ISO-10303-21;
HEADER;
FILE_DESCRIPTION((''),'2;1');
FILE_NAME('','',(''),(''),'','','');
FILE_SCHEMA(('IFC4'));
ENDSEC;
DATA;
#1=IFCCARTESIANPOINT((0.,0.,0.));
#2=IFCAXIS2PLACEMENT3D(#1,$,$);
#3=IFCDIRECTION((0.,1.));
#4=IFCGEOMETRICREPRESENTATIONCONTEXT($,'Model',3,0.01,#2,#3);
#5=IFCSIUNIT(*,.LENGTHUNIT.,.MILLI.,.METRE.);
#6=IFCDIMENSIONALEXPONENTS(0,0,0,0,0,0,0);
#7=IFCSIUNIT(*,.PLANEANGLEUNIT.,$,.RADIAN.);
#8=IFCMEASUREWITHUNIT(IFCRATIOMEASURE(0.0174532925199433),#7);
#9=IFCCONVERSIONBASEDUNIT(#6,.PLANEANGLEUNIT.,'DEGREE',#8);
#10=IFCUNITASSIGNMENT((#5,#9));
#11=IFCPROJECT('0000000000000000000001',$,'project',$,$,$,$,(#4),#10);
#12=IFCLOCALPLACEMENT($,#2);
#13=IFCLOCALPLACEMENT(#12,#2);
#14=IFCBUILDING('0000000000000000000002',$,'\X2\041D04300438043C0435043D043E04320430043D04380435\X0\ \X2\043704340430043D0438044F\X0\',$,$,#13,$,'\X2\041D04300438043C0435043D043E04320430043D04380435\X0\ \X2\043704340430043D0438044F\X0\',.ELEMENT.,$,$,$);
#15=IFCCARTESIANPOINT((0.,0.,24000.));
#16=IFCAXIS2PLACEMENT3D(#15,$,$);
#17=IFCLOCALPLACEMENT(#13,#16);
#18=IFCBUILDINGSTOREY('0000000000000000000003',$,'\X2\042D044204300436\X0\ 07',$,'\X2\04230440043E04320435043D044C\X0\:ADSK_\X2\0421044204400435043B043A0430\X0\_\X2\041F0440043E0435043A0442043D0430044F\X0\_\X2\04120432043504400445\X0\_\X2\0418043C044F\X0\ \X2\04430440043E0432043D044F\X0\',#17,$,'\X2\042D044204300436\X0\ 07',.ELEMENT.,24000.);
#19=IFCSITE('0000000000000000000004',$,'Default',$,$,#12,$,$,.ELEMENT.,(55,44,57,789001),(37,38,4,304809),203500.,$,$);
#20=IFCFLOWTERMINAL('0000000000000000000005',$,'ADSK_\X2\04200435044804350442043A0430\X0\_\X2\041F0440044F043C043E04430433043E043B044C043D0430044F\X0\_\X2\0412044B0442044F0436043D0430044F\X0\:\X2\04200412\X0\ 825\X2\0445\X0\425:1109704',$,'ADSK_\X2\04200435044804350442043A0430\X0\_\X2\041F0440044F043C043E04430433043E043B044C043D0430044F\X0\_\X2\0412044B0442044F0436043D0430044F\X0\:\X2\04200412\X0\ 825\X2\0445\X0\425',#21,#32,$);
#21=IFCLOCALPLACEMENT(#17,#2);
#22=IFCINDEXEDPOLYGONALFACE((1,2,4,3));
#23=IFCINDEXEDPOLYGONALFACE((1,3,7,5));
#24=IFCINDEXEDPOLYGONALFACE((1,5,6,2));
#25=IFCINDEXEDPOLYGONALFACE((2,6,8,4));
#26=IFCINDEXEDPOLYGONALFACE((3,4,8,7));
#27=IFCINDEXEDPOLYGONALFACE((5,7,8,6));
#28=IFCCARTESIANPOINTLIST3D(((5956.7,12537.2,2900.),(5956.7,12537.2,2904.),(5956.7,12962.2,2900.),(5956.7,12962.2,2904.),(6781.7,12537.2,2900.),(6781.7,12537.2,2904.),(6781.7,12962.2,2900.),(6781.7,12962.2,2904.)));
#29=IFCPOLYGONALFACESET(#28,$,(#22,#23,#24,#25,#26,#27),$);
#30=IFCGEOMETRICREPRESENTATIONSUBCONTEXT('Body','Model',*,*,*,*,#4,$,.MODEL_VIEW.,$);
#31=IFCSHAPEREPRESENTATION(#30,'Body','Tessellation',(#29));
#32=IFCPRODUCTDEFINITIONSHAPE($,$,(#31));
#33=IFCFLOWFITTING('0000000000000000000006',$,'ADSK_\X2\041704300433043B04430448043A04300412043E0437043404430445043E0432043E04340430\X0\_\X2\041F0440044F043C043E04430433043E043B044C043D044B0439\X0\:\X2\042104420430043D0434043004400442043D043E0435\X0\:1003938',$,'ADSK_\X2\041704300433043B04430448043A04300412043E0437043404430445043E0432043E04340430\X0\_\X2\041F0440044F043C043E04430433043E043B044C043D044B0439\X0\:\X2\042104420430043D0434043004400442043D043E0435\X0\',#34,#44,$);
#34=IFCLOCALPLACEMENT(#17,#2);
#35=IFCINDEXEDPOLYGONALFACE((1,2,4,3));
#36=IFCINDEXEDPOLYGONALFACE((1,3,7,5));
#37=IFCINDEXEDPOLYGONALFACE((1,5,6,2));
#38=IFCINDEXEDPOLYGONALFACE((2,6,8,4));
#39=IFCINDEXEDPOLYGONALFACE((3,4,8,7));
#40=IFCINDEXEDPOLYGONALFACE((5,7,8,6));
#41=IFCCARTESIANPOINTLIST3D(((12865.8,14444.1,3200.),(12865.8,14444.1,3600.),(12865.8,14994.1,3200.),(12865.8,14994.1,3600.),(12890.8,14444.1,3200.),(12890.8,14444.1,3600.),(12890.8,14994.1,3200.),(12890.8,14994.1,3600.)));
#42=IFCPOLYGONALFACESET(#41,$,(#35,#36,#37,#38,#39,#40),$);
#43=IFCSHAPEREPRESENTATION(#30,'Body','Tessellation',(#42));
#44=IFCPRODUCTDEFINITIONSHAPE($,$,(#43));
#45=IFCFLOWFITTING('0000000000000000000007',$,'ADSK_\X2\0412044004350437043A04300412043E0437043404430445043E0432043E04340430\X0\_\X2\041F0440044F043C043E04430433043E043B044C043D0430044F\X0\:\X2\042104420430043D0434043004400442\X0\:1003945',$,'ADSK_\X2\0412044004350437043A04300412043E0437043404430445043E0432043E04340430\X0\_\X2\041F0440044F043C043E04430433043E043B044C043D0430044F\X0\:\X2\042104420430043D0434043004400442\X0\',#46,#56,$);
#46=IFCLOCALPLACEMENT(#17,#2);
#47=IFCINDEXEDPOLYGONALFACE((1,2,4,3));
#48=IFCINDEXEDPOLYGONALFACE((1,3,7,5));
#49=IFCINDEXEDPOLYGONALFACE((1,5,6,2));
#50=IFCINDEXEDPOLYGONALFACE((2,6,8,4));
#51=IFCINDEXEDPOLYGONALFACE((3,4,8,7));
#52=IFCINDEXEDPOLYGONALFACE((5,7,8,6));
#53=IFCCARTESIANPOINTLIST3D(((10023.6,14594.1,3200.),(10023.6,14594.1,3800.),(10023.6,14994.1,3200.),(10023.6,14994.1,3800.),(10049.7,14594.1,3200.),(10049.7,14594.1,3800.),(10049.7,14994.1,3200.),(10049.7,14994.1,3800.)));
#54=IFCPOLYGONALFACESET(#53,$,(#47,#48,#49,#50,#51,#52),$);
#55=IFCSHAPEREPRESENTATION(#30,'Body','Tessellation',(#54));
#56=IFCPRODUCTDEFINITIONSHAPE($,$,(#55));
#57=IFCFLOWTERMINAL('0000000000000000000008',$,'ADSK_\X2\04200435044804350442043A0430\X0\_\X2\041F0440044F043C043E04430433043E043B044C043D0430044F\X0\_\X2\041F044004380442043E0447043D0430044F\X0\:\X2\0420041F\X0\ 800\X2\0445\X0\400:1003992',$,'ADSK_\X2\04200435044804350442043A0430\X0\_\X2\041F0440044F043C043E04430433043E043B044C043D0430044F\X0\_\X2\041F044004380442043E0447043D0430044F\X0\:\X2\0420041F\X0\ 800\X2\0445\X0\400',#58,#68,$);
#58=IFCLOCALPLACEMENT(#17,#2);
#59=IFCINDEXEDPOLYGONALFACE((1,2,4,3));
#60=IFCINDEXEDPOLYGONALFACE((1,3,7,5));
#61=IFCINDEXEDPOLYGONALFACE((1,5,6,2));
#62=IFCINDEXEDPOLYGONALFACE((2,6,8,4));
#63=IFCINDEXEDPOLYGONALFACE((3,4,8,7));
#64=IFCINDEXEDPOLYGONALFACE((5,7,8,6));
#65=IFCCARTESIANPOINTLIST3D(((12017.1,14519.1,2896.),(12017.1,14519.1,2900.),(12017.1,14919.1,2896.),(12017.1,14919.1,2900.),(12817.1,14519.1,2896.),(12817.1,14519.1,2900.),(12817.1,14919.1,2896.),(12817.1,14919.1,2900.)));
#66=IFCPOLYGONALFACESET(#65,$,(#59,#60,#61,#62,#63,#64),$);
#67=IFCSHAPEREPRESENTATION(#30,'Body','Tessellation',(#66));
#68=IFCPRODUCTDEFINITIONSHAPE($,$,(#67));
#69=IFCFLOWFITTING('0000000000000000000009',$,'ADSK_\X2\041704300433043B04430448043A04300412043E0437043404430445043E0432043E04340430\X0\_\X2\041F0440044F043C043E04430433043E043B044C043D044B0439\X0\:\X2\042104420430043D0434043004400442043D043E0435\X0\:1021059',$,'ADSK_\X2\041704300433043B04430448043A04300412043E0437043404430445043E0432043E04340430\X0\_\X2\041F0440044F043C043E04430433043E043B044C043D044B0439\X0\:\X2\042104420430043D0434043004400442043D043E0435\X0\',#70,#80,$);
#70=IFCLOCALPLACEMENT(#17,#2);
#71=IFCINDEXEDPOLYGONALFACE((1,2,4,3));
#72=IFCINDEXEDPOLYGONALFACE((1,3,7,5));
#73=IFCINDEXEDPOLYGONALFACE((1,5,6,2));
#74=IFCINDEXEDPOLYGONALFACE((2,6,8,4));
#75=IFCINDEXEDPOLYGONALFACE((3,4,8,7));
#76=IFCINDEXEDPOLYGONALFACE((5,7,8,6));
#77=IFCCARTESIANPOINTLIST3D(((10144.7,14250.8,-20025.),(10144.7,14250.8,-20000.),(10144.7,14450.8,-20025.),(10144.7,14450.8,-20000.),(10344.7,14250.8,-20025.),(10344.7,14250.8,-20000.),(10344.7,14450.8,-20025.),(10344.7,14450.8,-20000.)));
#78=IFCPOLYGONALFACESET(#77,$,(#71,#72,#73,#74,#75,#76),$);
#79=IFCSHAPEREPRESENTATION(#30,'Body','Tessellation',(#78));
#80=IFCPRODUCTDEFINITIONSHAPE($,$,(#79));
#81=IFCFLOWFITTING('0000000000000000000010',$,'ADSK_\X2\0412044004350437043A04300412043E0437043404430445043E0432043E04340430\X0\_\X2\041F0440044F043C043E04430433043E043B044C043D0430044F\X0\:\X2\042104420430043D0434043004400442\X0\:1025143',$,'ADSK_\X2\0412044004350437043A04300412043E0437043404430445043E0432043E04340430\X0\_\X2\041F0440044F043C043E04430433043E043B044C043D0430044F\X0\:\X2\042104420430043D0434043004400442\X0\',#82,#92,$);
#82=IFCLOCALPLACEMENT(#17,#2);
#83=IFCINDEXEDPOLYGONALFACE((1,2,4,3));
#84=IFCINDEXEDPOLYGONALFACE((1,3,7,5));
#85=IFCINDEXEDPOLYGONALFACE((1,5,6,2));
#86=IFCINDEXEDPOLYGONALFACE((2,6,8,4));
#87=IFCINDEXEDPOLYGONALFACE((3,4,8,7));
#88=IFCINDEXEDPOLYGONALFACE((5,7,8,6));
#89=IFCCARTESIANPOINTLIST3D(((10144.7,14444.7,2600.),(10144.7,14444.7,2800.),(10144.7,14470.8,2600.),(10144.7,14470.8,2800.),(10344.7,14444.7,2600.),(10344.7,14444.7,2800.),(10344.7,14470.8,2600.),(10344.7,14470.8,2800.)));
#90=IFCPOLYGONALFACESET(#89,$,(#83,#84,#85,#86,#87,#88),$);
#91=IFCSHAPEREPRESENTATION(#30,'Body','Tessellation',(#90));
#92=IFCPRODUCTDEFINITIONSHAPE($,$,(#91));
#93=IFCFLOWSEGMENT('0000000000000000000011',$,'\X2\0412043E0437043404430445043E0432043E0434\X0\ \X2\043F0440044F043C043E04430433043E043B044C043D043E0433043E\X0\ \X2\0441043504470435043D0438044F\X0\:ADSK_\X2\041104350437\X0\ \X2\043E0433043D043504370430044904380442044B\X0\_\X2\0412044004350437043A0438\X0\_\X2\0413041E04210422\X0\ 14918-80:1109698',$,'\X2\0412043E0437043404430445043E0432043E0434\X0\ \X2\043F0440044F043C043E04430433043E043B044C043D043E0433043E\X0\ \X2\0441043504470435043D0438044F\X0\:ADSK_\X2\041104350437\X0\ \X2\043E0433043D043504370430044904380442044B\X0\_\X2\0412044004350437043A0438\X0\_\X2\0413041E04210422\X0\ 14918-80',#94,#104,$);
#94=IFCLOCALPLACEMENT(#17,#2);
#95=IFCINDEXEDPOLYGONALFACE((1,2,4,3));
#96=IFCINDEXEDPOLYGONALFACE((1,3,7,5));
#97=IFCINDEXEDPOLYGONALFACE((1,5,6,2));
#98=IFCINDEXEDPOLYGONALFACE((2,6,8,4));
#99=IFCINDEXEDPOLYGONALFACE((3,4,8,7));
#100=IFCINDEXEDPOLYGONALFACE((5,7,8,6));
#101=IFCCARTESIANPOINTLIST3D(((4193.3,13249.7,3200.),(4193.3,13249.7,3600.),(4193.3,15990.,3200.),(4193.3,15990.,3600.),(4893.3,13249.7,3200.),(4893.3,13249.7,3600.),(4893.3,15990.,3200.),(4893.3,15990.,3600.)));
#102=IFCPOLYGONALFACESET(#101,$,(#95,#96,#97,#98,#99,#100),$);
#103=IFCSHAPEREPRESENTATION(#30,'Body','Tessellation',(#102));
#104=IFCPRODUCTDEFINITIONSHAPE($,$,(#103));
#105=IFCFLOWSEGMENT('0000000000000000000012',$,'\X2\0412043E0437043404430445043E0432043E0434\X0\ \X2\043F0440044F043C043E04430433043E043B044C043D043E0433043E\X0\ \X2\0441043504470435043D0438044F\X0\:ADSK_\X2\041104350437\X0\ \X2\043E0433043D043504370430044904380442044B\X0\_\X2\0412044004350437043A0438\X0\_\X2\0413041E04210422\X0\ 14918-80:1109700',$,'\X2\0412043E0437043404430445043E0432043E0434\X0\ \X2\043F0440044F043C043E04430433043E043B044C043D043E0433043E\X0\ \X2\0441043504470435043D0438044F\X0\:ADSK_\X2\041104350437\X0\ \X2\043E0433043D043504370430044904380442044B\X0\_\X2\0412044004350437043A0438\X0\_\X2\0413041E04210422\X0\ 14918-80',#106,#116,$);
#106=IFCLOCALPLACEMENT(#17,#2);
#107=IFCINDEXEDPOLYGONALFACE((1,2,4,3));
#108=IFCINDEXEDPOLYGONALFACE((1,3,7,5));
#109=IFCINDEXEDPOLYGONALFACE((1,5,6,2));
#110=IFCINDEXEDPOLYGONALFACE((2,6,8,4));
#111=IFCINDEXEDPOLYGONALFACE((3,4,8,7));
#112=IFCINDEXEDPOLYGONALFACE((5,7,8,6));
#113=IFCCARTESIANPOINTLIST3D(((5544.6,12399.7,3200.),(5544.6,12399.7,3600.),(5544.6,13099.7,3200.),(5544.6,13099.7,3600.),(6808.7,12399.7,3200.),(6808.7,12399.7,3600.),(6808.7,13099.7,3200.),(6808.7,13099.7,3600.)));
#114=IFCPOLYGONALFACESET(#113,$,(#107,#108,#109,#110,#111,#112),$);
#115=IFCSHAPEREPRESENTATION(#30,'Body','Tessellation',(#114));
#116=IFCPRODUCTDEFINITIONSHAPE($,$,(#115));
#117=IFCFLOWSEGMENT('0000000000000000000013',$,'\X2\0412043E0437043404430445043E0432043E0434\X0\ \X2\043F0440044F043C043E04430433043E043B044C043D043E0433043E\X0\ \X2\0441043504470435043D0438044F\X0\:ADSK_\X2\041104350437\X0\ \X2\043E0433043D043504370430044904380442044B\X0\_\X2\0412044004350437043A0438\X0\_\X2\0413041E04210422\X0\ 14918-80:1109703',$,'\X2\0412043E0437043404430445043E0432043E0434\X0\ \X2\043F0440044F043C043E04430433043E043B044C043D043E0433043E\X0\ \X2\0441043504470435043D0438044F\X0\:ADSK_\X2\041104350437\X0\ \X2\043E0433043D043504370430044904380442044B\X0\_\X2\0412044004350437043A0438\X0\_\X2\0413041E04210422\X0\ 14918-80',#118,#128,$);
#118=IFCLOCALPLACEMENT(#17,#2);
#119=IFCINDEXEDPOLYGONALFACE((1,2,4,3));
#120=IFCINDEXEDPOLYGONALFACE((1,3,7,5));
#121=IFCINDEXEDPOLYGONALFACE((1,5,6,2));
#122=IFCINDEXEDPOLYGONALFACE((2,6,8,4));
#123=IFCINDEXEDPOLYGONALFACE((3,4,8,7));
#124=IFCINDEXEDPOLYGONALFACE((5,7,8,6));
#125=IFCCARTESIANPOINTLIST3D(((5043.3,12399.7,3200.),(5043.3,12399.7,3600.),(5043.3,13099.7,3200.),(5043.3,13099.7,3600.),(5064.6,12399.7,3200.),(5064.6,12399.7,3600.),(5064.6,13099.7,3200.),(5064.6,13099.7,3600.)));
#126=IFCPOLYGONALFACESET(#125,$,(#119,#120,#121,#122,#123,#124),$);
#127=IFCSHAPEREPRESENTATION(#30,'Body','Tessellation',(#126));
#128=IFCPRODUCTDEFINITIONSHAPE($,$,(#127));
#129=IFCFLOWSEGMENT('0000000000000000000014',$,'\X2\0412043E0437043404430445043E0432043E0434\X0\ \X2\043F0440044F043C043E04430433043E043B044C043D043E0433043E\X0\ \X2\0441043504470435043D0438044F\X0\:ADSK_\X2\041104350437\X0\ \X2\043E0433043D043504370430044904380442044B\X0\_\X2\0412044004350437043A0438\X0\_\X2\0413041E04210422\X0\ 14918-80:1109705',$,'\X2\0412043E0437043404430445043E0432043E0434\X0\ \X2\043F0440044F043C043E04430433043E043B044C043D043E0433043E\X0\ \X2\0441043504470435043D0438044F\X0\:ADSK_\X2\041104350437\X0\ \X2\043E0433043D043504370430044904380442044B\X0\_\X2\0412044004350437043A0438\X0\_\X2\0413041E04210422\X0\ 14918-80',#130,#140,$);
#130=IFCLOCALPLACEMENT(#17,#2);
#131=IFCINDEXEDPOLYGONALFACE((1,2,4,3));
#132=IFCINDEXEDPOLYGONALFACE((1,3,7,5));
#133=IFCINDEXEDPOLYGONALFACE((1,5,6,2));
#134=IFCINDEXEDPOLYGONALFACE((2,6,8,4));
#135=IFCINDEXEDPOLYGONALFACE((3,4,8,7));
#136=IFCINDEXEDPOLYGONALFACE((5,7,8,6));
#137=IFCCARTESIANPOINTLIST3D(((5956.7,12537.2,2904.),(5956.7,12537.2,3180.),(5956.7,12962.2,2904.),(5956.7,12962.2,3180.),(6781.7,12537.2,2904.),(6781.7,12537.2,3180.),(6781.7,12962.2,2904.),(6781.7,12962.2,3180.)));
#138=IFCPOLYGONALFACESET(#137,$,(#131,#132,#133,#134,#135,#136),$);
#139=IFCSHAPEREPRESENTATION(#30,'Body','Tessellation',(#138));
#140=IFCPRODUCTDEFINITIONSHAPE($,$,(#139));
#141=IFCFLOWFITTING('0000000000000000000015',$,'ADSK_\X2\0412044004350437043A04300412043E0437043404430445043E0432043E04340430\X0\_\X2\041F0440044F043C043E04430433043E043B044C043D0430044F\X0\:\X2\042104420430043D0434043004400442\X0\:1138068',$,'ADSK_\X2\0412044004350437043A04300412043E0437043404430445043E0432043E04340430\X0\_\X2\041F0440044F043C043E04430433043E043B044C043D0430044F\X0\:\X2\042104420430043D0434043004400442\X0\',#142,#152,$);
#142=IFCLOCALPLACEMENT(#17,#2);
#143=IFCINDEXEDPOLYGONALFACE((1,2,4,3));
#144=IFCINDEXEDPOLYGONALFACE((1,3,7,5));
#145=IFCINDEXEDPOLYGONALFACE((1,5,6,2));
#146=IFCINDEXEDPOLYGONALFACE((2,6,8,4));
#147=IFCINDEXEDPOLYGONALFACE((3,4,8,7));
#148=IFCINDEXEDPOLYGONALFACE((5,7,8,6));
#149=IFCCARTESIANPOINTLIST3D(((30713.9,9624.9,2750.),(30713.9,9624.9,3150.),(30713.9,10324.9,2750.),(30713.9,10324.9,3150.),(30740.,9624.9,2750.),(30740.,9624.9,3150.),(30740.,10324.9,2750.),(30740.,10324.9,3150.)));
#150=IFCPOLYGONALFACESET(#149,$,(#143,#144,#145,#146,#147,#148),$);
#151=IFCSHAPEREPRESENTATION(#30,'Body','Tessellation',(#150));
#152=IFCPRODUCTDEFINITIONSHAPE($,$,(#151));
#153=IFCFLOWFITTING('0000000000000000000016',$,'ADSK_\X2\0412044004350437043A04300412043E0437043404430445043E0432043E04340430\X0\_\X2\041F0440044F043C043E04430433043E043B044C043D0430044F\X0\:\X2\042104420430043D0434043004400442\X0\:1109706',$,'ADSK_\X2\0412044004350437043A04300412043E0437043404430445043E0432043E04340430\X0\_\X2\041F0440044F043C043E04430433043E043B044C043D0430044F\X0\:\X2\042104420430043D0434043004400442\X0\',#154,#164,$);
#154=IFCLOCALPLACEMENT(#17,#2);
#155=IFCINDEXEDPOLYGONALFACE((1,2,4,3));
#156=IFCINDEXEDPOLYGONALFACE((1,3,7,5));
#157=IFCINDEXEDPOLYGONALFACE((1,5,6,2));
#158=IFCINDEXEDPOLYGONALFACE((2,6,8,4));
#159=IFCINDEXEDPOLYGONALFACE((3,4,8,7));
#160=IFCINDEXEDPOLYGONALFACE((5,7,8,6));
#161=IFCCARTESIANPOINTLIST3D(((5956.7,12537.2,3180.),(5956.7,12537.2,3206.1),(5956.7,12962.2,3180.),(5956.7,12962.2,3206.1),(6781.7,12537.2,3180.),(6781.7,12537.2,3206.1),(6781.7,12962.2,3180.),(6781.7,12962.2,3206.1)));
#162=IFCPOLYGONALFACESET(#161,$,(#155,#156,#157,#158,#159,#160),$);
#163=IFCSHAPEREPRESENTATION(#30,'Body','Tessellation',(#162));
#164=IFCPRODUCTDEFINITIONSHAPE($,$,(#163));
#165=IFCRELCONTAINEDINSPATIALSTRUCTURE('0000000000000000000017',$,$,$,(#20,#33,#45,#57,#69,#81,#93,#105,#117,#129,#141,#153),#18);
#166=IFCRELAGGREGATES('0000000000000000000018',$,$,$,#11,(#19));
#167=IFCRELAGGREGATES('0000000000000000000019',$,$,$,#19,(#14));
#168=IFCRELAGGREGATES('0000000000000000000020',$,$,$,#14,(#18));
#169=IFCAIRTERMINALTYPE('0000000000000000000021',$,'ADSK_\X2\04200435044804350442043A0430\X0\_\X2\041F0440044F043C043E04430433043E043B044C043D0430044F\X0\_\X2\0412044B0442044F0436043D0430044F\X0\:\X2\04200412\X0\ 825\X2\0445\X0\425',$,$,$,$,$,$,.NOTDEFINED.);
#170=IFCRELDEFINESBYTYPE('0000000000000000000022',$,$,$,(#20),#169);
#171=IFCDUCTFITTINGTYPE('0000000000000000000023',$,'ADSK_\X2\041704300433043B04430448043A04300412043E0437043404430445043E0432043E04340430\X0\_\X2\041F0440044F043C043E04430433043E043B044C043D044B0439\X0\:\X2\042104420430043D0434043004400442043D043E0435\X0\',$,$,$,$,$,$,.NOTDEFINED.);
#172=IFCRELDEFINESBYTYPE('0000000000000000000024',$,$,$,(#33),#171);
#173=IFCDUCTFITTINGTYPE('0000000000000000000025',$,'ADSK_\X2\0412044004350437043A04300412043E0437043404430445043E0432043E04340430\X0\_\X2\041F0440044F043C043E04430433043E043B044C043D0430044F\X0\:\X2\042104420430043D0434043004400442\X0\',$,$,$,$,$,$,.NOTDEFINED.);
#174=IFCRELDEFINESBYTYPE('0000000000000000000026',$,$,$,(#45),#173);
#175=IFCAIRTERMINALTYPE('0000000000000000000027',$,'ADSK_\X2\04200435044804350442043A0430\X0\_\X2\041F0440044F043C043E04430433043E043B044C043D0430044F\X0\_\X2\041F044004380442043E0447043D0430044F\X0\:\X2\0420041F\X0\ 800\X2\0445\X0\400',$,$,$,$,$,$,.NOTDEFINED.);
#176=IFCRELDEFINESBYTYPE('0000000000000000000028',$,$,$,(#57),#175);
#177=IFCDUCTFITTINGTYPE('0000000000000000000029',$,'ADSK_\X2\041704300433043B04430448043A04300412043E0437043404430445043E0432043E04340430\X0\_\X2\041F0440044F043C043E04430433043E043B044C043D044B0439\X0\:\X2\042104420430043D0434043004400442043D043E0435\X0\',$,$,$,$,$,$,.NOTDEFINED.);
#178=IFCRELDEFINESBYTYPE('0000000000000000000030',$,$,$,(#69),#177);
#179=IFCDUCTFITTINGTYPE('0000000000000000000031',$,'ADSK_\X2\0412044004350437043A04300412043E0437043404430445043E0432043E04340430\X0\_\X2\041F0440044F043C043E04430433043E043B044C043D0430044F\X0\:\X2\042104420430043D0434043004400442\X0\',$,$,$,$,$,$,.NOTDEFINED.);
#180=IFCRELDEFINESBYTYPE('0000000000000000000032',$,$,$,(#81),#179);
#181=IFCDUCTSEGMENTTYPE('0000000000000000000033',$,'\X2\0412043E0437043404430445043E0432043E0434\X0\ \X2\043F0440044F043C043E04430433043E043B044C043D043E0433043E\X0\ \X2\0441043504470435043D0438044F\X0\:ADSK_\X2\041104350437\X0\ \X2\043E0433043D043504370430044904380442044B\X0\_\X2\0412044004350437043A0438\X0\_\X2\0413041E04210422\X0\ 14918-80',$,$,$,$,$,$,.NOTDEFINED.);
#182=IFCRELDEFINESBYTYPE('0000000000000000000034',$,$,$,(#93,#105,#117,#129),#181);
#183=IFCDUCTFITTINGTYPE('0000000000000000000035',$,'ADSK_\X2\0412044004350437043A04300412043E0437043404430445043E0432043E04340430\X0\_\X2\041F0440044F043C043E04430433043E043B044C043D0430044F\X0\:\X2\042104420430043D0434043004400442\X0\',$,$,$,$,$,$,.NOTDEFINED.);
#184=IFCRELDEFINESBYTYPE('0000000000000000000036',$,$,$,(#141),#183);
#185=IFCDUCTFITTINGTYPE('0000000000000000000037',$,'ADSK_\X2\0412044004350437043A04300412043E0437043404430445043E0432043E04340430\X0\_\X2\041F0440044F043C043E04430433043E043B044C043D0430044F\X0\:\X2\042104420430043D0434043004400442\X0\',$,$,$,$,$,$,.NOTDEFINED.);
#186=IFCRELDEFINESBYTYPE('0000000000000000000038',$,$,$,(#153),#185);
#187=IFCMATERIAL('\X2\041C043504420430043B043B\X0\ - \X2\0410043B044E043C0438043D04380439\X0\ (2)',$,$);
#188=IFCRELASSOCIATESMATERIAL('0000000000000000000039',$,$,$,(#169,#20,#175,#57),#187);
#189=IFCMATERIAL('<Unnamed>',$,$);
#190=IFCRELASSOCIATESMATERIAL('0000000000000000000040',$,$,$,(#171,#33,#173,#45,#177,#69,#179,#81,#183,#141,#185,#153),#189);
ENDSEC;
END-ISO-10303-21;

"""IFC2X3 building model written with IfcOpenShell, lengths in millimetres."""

from ifc_helpers import new_model, entity, si_unit, converted_unit, direction, frame, frame_2d, origin, origin_2d_with_axis, place, context, subcontext, project, spatial, rectangle, extrude, source, transform, mapped, material, type_object, type_shapes, element, save


model = new_model("IFC2X3")

# Units and contexts
model_context = context("Model", 3, precision=0.01, world=origin(), true_north=direction((0.0, 1.0)))
body_context = subcontext(model_context, "Body", "Model", "MODEL_VIEW")
ifc_project = project(units=[si_unit("LENGTHUNIT", "METRE", prefix="MILLI"), converted_unit("PLANEANGLEUNIT", "DEGREE", entity("IfcRatioMeasure", 0.0174532925199433), si_unit("PLANEANGLEUNIT", "RADIAN"), dimensions=[0, 0, 0, 0, 0, 0, 0])], contexts=[model_context])

# Site, building, storey
site_placement = place(None, frame((0.0, 0.0, 0.0)))
site = spatial("IfcSite", under=ifc_project, at=site_placement, Name="Default", CompositionType="ELEMENT", RefLatitude=(55, 44, 57, 789001), RefLongitude=(37, 38, 4, 304809), RefElevation=203500.0)
building_placement = place(site_placement, origin())
building = spatial("IfcBuilding", under=site, at=building_placement, Name="Наименование здания", LongName="Наименование здания", CompositionType="ELEMENT")
storey_placement = place(building_placement, frame((0.0, 0.0, 24000.0)))
storey = spatial("IfcBuildingStorey", under=building, at=storey_placement, Name="Этаж 07", ObjectType="Уровень:ADSK_Стрелка_Проектная_Вверх_Имя уровня", LongName="Этаж 07", CompositionType="ELEMENT", Elevation=24000.0)

# Shared definitions
ifc_material_1 = material(Name="<Unnamed>")

# Flow terminal
ifc_material_2 = material(Name="Металл - Алюминий (2)")
air_terminal_type_1 = type_object("IfcAirTerminalType", Name="ADSK_Решетка_Прямоугольная_Вытяжная:РВ 825х425", PredefinedType="NOTDEFINED", material=ifc_material_2)
shared_shape_1 = source(origin(), body_context, "Body", "SweptSolid", [
    extrude(rectangle(XDim=4.0, YDim=825.0, at=origin_2d_with_axis()), frame((0.0, -2.0, -212.5), z_axis=(0.0, 0.0, 1.0), x_axis=(0.0, 1.0, 0.0)), (0.0, 0.0, 1.0), 425.0),
])
type_shapes(air_terminal_type_1, [shared_shape_1])
flow_terminal_1_placement = place(storey_placement, frame((6369.2, 12749.7, 2904.0), z_axis=(0.0, 1.0, 0.0), x_axis=(-1.0, 0.0, 0.0)))
element("IfcFlowTerminal", 1, at=flow_terminal_1_placement, inside=storey, type_object=air_terminal_type_1, material=ifc_material_2, Name="ADSK_Решетка_Прямоугольная_Вытяжная:РВ 825х425:1109704", ObjectType="ADSK_Решетка_Прямоугольная_Вытяжная:РВ 825х425", context=body_context, shape_type="MappedRepresentation", body=[
    mapped(shared_shape_1, transform((0.0, 0.0, 0.0), scale=1.0)),
])

# Flow fittings
duct_fitting_type_1 = type_object("IfcDuctFittingType", Name="ADSK_ЗаглушкаВоздуховода_Прямоугольный:Стандартное", PredefinedType="NOTDEFINED", material=ifc_material_1)
shared_shape_2 = source(origin(), body_context, "Body", "SweptSolid", [
    extrude(rectangle(XDim=25.0, YDim=550.0, at=frame_2d((0.0, 0.0), x_axis=(1.0, 0.0))), frame((12.5, 0.0, -200.0)), (0.0, 0.0, 1.0), 400.0),
])
type_shapes(duct_fitting_type_1, [shared_shape_2])
flow_fitting_1_placement = place(storey_placement, frame((12865.8, 14719.1, 3400.0)))
element("IfcFlowFitting", 2, at=flow_fitting_1_placement, inside=storey, type_object=duct_fitting_type_1, material=ifc_material_1, Name="ADSK_ЗаглушкаВоздуховода_Прямоугольный:Стандартное:1003938", ObjectType="ADSK_ЗаглушкаВоздуховода_Прямоугольный:Стандартное", context=body_context, shape_type="MappedRepresentation", body=[
    mapped(shared_shape_2, transform((0.0, 0.0, 0.0), scale=1.0)),
])
duct_fitting_type_2 = type_object("IfcDuctFittingType", Name="ADSK_ВрезкаВоздуховода_Прямоугольная:Стандарт", PredefinedType="NOTDEFINED", material=ifc_material_1)
shared_shape_3 = source(origin(), body_context, "Body", "SweptSolid", [
    extrude(rectangle(XDim=600.0, YDim=26.1, at=origin_2d_with_axis()), frame((7.0, 0.0, -200.0), z_axis=(0.0, 0.0, 1.0), x_axis=(0.0, -1.0, 0.0)), (0.0, 0.0, 1.0), 400.0),
])
type_shapes(duct_fitting_type_2, [shared_shape_3])
flow_fitting_2_placement = place(storey_placement, frame((10029.7, 14794.1, 3500.0), z_axis=(0.0, -1.0, 0.0), x_axis=(1.0, 0.0, 0.0)))
element("IfcFlowFitting", 3, at=flow_fitting_2_placement, inside=storey, type_object=duct_fitting_type_2, material=ifc_material_1, Name="ADSK_ВрезкаВоздуховода_Прямоугольная:Стандарт:1003945", ObjectType="ADSK_ВрезкаВоздуховода_Прямоугольная:Стандарт", context=body_context, shape_type="MappedRepresentation", body=[
    mapped(shared_shape_3, transform((0.0, 0.0, 0.0), scale=1.0)),
])

# Flow terminal
air_terminal_type_2 = type_object("IfcAirTerminalType", Name="ADSK_Решетка_Прямоугольная_Приточная:РП 800х400", PredefinedType="NOTDEFINED", material=ifc_material_2)
shared_shape_4 = source(origin(), body_context, "Body", "SweptSolid", [
    extrude(rectangle(XDim=4.0, YDim=800.0, at=origin_2d_with_axis()), frame((0.0, -2.0, -200.0), z_axis=(0.0, 0.0, 1.0), x_axis=(0.0, 1.0, 0.0)), (0.0, 0.0, 1.0), 400.0),
])
type_shapes(air_terminal_type_2, [shared_shape_4])
flow_terminal_2_placement = place(storey_placement, frame((12417.1, 14719.1, 2900.0), z_axis=(0.0, 1.0, 0.0), x_axis=(-1.0, 0.0, 0.0)))
element("IfcFlowTerminal", 4, at=flow_terminal_2_placement, inside=storey, type_object=air_terminal_type_2, material=ifc_material_2, Name="ADSK_Решетка_Прямоугольная_Приточная:РП 800х400:1003992", ObjectType="ADSK_Решетка_Прямоугольная_Приточная:РП 800х400", context=body_context, shape_type="MappedRepresentation", body=[
    mapped(shared_shape_4, transform((0.0, 0.0, 0.0), scale=1.0)),
])

# Flow fittings
duct_fitting_type_3 = type_object("IfcDuctFittingType", Name="ADSK_ЗаглушкаВоздуховода_Прямоугольный:Стандартное", PredefinedType="NOTDEFINED", material=ifc_material_1)
shared_shape_5 = source(origin(), body_context, "Body", "SweptSolid", [
    extrude(rectangle(XDim=25.0, YDim=200.0, at=frame_2d((0.0, 0.0), x_axis=(1.0, 0.0))), frame((12.5, 0.0, -100.0)), (0.0, 0.0, 1.0), 200.0),
])
type_shapes(duct_fitting_type_3, [shared_shape_5])
flow_fitting_3_placement = place(storey_placement, frame((10244.7, 14350.8, -20000.0), z_axis=(0.0, -1.0, 0.0), x_axis=(0.0, 0.0, -1.0)))
element("IfcFlowFitting", 5, at=flow_fitting_3_placement, inside=storey, type_object=duct_fitting_type_3, material=ifc_material_1, Name="ADSK_ЗаглушкаВоздуховода_Прямоугольный:Стандартное:1021059", ObjectType="ADSK_ЗаглушкаВоздуховода_Прямоугольный:Стандартное", context=body_context, shape_type="MappedRepresentation", body=[
    mapped(shared_shape_5, transform((0.0, 0.0, 0.0), scale=1.0)),
])
duct_fitting_type_4 = type_object("IfcDuctFittingType", Name="ADSK_ВрезкаВоздуховода_Прямоугольная:Стандарт", PredefinedType="NOTDEFINED", material=ifc_material_1)
shared_shape_6 = source(origin(), body_context, "Body", "SweptSolid", [
    extrude(rectangle(XDim=200.0, YDim=26.1, at=frame_2d((0.0, 0.0), x_axis=(1.0, 0.0))), frame((7.0, 0.0, -100.0), z_axis=(0.0, 0.0, 1.0), x_axis=(0.0, -1.0, 0.0)), (0.0, 0.0, 1.0), 200.0),
])
type_shapes(duct_fitting_type_4, [shared_shape_6])
flow_fitting_4_placement = place(storey_placement, frame((10244.7, 14450.8, 2700.0), z_axis=(1.0, 0.0, 0.0), x_axis=(0.0, 1.0, 0.0)))
element("IfcFlowFitting", 6, at=flow_fitting_4_placement, inside=storey, type_object=duct_fitting_type_4, material=ifc_material_1, Name="ADSK_ВрезкаВоздуховода_Прямоугольная:Стандарт:1025143", ObjectType="ADSK_ВрезкаВоздуховода_Прямоугольная:Стандарт", context=body_context, shape_type="MappedRepresentation", body=[
    mapped(shared_shape_6, transform((0.0, 0.0, 0.0), scale=1.0)),
])

# Flow segments
duct_segment_type_1 = type_object("IfcDuctSegmentType", Name="Воздуховод прямоугольного сечения:ADSK_Без огнезащиты_Врезки_ГОСТ 14918-80", PredefinedType="NOTDEFINED")
flow_segment_1_placement = place(storey_placement, frame((4193.3, 13249.7, 3200.0)))
element("IfcFlowSegment", 7, at=flow_segment_1_placement, inside=storey, type_object=duct_segment_type_1, Name="Воздуховод прямоугольного сечения:ADSK_Без огнезащиты_Врезки_ГОСТ 14918-80:1109698", ObjectType="Воздуховод прямоугольного сечения:ADSK_Без огнезащиты_Врезки_ГОСТ 14918-80", context=body_context, shape_type="SweptSolid", body=[
    extrude(rectangle(XDim=2740.3, YDim=700.0, at=frame_2d((0.0, 0.0), x_axis=(1.0, 0.0))), frame((350.0, 1370.2, 0.0), z_axis=(0.0, 0.0, 1.0), x_axis=(0.0, 1.0, 0.0)), (0.0, 0.0, 1.0), 400.0),
])
flow_segment_2_placement = place(storey_placement, frame((5544.6, 12399.7, 3200.0)))
element("IfcFlowSegment", 8, at=flow_segment_2_placement, inside=storey, type_object=duct_segment_type_1, Name="Воздуховод прямоугольного сечения:ADSK_Без огнезащиты_Врезки_ГОСТ 14918-80:1109700", ObjectType="Воздуховод прямоугольного сечения:ADSK_Без огнезащиты_Врезки_ГОСТ 14918-80", context=body_context, shape_type="SweptSolid", body=[
    extrude(rectangle(XDim=1264.1, YDim=700.0, at=frame_2d((0.0, 0.0), x_axis=(1.0, 0.0))), frame((632.0, 350.0, 0.0)), (0.0, 0.0, 1.0), 400.0),
])
flow_segment_3_placement = place(storey_placement, frame((5043.3, 12399.7, 3200.0)))
element("IfcFlowSegment", 9, at=flow_segment_3_placement, inside=storey, type_object=duct_segment_type_1, Name="Воздуховод прямоугольного сечения:ADSK_Без огнезащиты_Врезки_ГОСТ 14918-80:1109703", ObjectType="Воздуховод прямоугольного сечения:ADSK_Без огнезащиты_Врезки_ГОСТ 14918-80", context=body_context, shape_type="SweptSolid", body=[
    extrude(rectangle(XDim=21.3, YDim=700.0, at=frame_2d((0.0, 0.0), x_axis=(1.0, 0.0))), frame((10.7, 350.0, 0.0)), (0.0, 0.0, 1.0), 400.0),
])
flow_segment_4_placement = place(storey_placement, frame((5956.7, 12537.2, 2904.0)))
element("IfcFlowSegment", 10, at=flow_segment_4_placement, inside=storey, type_object=duct_segment_type_1, Name="Воздуховод прямоугольного сечения:ADSK_Без огнезащиты_Врезки_ГОСТ 14918-80:1109705", ObjectType="Воздуховод прямоугольного сечения:ADSK_Без огнезащиты_Врезки_ГОСТ 14918-80", context=body_context, shape_type="SweptSolid", body=[
    extrude(rectangle(XDim=825.0, YDim=425.0, at=frame_2d((0.0, 0.0), x_axis=(1.0, 0.0))), frame((412.5, 212.5, 0.0), z_axis=(0.0, 0.0, 1.0), x_axis=(-1.0, 0.0, 0.0)), (0.0, 0.0, 1.0), 276.0),
])

# Flow fittings
duct_fitting_type_5 = type_object("IfcDuctFittingType", Name="ADSK_ВрезкаВоздуховода_Прямоугольная:Стандарт", PredefinedType="NOTDEFINED", material=ifc_material_1)
shared_shape_7 = source(origin(), body_context, "Body", "SweptSolid", [
    extrude(rectangle(XDim=700.0, YDim=26.1, at=frame_2d((0.0, 0.0), x_axis=(1.0, 0.0))), frame((7.0, 0.0, -200.0), z_axis=(0.0, 0.0, 1.0), x_axis=(0.0, -1.0, 0.0)), (0.0, 0.0, 1.0), 400.0),
])
type_shapes(duct_fitting_type_5, [shared_shape_7])
flow_fitting_5_placement = place(storey_placement, frame((30720.0, 9974.9, 2950.0), z_axis=(0.0, 0.0, -1.0), x_axis=(1.0, 0.0, 0.0)))
element("IfcFlowFitting", 11, at=flow_fitting_5_placement, inside=storey, type_object=duct_fitting_type_5, material=ifc_material_1, Name="ADSK_ВрезкаВоздуховода_Прямоугольная:Стандарт:1138068", ObjectType="ADSK_ВрезкаВоздуховода_Прямоугольная:Стандарт", context=body_context, shape_type="MappedRepresentation", body=[
    mapped(shared_shape_7, transform((0.0, 0.0, 0.0), scale=1.0)),
])
duct_fitting_type_6 = type_object("IfcDuctFittingType", Name="ADSK_ВрезкаВоздуховода_Прямоугольная:Стандарт", PredefinedType="NOTDEFINED", material=ifc_material_1)
shared_shape_8 = source(origin(), body_context, "Body", "SweptSolid", [
    extrude(rectangle(XDim=825.0, YDim=26.1, at=frame_2d((0.0, 0.0), x_axis=(1.0, 0.0))), frame((7.0, 0.0, -212.5), z_axis=(0.0, 0.0, 1.0), x_axis=(0.0, -1.0, 0.0)), (0.0, 0.0, 1.0), 425.0),
])
type_shapes(duct_fitting_type_6, [shared_shape_8])
flow_fitting_6_placement = place(storey_placement, frame((6369.2, 12749.7, 3200.0), z_axis=(0.0, -1.0, 0.0), x_axis=(0.0, 0.0, -1.0)))
element("IfcFlowFitting", 12, at=flow_fitting_6_placement, inside=storey, type_object=duct_fitting_type_6, material=ifc_material_1, Name="ADSK_ВрезкаВоздуховода_Прямоугольная:Стандарт:1109706", ObjectType="ADSK_ВрезкаВоздуховода_Прямоугольная:Стандарт", context=body_context, shape_type="MappedRepresentation", body=[
    mapped(shared_shape_8, transform((0.0, 0.0, 0.0), scale=1.0)),
])

save(model, "model.ifc")
